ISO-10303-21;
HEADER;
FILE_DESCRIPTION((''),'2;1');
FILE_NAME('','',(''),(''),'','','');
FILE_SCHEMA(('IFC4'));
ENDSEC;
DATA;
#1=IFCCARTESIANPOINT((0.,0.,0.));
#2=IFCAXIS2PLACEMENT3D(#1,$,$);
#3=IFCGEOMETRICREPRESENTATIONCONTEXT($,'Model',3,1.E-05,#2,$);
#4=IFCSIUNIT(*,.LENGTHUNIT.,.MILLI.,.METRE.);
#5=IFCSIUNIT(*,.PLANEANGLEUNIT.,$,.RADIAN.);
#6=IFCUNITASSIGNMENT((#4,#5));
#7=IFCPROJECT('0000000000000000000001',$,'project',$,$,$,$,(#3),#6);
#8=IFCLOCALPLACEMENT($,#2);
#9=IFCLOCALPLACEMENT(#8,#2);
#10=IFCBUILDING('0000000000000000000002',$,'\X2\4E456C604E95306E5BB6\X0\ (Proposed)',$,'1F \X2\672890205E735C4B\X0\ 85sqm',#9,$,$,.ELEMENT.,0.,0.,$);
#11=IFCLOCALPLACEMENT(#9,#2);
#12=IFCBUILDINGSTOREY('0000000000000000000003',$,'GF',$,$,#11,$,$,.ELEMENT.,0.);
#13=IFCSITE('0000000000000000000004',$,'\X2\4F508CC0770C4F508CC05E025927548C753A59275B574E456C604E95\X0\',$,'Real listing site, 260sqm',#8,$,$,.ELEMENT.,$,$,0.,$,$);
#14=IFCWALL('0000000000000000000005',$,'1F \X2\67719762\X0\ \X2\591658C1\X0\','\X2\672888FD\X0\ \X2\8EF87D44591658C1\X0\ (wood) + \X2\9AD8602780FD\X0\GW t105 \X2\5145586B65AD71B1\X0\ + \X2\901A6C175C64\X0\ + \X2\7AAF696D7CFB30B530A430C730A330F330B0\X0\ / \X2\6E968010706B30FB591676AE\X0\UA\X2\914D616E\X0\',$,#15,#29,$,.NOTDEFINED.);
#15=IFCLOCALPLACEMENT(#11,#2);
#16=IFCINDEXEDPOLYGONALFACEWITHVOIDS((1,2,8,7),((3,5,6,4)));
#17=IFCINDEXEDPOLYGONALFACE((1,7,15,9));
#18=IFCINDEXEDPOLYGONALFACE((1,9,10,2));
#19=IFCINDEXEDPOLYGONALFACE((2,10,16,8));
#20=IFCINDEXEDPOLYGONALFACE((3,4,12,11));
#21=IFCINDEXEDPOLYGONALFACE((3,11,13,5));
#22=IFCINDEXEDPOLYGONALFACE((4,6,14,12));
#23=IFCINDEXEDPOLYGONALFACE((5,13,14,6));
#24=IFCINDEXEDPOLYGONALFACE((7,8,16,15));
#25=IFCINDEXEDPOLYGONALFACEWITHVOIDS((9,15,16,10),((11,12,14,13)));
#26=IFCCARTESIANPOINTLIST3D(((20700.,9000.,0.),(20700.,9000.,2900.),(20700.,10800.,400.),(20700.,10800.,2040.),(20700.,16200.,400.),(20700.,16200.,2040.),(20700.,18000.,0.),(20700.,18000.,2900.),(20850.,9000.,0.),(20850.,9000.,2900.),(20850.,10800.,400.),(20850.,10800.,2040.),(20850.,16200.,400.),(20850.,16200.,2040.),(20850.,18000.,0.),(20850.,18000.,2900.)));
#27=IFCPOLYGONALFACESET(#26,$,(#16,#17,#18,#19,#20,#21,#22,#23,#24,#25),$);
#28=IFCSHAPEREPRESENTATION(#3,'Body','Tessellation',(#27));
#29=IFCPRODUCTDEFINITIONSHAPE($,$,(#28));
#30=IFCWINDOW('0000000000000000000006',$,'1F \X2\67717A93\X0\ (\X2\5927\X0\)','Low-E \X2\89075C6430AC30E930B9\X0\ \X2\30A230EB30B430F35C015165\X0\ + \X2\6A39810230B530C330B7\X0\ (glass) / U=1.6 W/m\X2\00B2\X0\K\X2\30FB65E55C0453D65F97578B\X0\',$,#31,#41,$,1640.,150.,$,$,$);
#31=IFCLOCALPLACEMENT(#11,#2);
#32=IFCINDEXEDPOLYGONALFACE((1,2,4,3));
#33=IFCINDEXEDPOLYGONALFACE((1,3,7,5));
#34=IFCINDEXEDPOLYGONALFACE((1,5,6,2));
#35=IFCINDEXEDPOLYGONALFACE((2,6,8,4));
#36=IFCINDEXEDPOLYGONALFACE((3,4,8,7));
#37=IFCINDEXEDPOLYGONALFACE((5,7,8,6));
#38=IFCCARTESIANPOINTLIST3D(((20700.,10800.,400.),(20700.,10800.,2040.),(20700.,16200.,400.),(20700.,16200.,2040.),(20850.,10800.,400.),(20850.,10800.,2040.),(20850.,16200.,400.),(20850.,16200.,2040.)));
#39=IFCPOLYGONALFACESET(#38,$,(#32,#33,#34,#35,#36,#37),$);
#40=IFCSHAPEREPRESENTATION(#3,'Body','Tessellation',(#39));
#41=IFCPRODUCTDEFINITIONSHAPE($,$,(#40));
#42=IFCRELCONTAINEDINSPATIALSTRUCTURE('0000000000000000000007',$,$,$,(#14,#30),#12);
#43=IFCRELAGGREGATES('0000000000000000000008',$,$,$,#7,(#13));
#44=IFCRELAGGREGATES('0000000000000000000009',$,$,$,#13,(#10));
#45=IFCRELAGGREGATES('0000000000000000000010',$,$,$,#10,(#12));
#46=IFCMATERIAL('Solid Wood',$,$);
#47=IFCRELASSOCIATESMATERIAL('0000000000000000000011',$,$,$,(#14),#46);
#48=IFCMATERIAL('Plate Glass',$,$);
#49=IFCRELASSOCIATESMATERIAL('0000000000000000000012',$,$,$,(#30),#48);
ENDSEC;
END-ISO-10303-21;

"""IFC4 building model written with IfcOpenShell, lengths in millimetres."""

from ifc_helpers import new_model, si_unit, frame, frame_2d, origin, place, context, project, spatial, rectangle, extrude, material, element, fill, save


model = new_model("IFC4")

# Units and contexts
model_context = context("Model", 3, precision=1e-05, world=origin())
ifc_project = project(units=[si_unit("LENGTHUNIT", "METRE", prefix="MILLI"), si_unit("PLANEANGLEUNIT", "RADIAN")], contexts=[model_context])

# Site, building, storey
site_placement = place(None, origin())
site = spatial("IfcSite", under=ifc_project, at=site_placement, Name="佐賀県佐賀市大和町大字久池井", ObjectType="Real listing site, 260sqm", CompositionType="ELEMENT", RefElevation=0.0)
building_placement = place(site_placement, origin())
building = spatial("IfcBuilding", under=site, at=building_placement, Name="久池井の家 (Proposed)", ObjectType="1F 木造平屋 85sqm", CompositionType="ELEMENT", ElevationOfRefHeight=0.0, ElevationOfTerrain=0.0)
storey_placement = place(building_placement, origin())
storey = spatial("IfcBuildingStorey", under=building, at=storey_placement, Name="GF", CompositionType="ELEMENT", Elevation=0.0)

# Wall, opening, window
ifc_material_1 = material(Name="Solid Wood")
wall_1_placement = place(storey_placement, frame((10350.0, 4500.0, 0.0)))
wall_1 = element("IfcWall", 1, at=wall_1_placement, inside=storey, material=ifc_material_1, Name="1F 東面 外壁", Description="木製 軸組外壁 (wood) + 高性能GW t105 充填断熱 + 通気層 + 窯業系サイディング / 準耐火・外皮UA配慮", PredefinedType="NOTDEFINED", context=model_context, shape_type="SweptSolid", body=[
    extrude(rectangle(XDim=150.0, YDim=9000.0, at=frame_2d((75.0, 4500.0))), frame((10350.0, 4500.0, 0.0)), (0.0, 0.0, 1.0), 2900.0),
])
opening_1_placement = place(storey_placement, frame((10350.0, 5400.0, 200.0)))
opening_1 = element("IfcOpeningElement", 2, at=opening_1_placement, cuts=wall_1, PredefinedType="NOTDEFINED", context=model_context, shape_type="SweptSolid", body=[
    extrude(rectangle(XDim=150.0, YDim=5400.0, at=frame_2d((75.0, 2700.0))), frame((10350.0, 5400.0, 200.0)), (0.0, 0.0, 1.0), 1640.0),
])
ifc_material_2 = material(Name="Plate Glass")
window_1_placement = place(storey_placement, frame((10350.0, 5400.0, 200.0)))
window_1 = element("IfcWindow", 3, at=window_1_placement, inside=storey, material=ifc_material_2, Name="1F 東窓 (大)", Description="Low-E 複層ガラス アルゴン封入 + 樹脂サッシ (glass) / U=1.6 W/m²K・日射取得型", OverallHeight=1640.0, OverallWidth=150.0, context=model_context, shape_type="SweptSolid", body=[
    extrude(rectangle(XDim=150.0, YDim=5400.0, at=frame_2d((75.0, 2700.0))), frame((10350.0, 5400.0, 200.0)), (0.0, 0.0, 1.0), 1640.0),
])
fill(opening_1, window_1)

save(model, "model.ifc")
